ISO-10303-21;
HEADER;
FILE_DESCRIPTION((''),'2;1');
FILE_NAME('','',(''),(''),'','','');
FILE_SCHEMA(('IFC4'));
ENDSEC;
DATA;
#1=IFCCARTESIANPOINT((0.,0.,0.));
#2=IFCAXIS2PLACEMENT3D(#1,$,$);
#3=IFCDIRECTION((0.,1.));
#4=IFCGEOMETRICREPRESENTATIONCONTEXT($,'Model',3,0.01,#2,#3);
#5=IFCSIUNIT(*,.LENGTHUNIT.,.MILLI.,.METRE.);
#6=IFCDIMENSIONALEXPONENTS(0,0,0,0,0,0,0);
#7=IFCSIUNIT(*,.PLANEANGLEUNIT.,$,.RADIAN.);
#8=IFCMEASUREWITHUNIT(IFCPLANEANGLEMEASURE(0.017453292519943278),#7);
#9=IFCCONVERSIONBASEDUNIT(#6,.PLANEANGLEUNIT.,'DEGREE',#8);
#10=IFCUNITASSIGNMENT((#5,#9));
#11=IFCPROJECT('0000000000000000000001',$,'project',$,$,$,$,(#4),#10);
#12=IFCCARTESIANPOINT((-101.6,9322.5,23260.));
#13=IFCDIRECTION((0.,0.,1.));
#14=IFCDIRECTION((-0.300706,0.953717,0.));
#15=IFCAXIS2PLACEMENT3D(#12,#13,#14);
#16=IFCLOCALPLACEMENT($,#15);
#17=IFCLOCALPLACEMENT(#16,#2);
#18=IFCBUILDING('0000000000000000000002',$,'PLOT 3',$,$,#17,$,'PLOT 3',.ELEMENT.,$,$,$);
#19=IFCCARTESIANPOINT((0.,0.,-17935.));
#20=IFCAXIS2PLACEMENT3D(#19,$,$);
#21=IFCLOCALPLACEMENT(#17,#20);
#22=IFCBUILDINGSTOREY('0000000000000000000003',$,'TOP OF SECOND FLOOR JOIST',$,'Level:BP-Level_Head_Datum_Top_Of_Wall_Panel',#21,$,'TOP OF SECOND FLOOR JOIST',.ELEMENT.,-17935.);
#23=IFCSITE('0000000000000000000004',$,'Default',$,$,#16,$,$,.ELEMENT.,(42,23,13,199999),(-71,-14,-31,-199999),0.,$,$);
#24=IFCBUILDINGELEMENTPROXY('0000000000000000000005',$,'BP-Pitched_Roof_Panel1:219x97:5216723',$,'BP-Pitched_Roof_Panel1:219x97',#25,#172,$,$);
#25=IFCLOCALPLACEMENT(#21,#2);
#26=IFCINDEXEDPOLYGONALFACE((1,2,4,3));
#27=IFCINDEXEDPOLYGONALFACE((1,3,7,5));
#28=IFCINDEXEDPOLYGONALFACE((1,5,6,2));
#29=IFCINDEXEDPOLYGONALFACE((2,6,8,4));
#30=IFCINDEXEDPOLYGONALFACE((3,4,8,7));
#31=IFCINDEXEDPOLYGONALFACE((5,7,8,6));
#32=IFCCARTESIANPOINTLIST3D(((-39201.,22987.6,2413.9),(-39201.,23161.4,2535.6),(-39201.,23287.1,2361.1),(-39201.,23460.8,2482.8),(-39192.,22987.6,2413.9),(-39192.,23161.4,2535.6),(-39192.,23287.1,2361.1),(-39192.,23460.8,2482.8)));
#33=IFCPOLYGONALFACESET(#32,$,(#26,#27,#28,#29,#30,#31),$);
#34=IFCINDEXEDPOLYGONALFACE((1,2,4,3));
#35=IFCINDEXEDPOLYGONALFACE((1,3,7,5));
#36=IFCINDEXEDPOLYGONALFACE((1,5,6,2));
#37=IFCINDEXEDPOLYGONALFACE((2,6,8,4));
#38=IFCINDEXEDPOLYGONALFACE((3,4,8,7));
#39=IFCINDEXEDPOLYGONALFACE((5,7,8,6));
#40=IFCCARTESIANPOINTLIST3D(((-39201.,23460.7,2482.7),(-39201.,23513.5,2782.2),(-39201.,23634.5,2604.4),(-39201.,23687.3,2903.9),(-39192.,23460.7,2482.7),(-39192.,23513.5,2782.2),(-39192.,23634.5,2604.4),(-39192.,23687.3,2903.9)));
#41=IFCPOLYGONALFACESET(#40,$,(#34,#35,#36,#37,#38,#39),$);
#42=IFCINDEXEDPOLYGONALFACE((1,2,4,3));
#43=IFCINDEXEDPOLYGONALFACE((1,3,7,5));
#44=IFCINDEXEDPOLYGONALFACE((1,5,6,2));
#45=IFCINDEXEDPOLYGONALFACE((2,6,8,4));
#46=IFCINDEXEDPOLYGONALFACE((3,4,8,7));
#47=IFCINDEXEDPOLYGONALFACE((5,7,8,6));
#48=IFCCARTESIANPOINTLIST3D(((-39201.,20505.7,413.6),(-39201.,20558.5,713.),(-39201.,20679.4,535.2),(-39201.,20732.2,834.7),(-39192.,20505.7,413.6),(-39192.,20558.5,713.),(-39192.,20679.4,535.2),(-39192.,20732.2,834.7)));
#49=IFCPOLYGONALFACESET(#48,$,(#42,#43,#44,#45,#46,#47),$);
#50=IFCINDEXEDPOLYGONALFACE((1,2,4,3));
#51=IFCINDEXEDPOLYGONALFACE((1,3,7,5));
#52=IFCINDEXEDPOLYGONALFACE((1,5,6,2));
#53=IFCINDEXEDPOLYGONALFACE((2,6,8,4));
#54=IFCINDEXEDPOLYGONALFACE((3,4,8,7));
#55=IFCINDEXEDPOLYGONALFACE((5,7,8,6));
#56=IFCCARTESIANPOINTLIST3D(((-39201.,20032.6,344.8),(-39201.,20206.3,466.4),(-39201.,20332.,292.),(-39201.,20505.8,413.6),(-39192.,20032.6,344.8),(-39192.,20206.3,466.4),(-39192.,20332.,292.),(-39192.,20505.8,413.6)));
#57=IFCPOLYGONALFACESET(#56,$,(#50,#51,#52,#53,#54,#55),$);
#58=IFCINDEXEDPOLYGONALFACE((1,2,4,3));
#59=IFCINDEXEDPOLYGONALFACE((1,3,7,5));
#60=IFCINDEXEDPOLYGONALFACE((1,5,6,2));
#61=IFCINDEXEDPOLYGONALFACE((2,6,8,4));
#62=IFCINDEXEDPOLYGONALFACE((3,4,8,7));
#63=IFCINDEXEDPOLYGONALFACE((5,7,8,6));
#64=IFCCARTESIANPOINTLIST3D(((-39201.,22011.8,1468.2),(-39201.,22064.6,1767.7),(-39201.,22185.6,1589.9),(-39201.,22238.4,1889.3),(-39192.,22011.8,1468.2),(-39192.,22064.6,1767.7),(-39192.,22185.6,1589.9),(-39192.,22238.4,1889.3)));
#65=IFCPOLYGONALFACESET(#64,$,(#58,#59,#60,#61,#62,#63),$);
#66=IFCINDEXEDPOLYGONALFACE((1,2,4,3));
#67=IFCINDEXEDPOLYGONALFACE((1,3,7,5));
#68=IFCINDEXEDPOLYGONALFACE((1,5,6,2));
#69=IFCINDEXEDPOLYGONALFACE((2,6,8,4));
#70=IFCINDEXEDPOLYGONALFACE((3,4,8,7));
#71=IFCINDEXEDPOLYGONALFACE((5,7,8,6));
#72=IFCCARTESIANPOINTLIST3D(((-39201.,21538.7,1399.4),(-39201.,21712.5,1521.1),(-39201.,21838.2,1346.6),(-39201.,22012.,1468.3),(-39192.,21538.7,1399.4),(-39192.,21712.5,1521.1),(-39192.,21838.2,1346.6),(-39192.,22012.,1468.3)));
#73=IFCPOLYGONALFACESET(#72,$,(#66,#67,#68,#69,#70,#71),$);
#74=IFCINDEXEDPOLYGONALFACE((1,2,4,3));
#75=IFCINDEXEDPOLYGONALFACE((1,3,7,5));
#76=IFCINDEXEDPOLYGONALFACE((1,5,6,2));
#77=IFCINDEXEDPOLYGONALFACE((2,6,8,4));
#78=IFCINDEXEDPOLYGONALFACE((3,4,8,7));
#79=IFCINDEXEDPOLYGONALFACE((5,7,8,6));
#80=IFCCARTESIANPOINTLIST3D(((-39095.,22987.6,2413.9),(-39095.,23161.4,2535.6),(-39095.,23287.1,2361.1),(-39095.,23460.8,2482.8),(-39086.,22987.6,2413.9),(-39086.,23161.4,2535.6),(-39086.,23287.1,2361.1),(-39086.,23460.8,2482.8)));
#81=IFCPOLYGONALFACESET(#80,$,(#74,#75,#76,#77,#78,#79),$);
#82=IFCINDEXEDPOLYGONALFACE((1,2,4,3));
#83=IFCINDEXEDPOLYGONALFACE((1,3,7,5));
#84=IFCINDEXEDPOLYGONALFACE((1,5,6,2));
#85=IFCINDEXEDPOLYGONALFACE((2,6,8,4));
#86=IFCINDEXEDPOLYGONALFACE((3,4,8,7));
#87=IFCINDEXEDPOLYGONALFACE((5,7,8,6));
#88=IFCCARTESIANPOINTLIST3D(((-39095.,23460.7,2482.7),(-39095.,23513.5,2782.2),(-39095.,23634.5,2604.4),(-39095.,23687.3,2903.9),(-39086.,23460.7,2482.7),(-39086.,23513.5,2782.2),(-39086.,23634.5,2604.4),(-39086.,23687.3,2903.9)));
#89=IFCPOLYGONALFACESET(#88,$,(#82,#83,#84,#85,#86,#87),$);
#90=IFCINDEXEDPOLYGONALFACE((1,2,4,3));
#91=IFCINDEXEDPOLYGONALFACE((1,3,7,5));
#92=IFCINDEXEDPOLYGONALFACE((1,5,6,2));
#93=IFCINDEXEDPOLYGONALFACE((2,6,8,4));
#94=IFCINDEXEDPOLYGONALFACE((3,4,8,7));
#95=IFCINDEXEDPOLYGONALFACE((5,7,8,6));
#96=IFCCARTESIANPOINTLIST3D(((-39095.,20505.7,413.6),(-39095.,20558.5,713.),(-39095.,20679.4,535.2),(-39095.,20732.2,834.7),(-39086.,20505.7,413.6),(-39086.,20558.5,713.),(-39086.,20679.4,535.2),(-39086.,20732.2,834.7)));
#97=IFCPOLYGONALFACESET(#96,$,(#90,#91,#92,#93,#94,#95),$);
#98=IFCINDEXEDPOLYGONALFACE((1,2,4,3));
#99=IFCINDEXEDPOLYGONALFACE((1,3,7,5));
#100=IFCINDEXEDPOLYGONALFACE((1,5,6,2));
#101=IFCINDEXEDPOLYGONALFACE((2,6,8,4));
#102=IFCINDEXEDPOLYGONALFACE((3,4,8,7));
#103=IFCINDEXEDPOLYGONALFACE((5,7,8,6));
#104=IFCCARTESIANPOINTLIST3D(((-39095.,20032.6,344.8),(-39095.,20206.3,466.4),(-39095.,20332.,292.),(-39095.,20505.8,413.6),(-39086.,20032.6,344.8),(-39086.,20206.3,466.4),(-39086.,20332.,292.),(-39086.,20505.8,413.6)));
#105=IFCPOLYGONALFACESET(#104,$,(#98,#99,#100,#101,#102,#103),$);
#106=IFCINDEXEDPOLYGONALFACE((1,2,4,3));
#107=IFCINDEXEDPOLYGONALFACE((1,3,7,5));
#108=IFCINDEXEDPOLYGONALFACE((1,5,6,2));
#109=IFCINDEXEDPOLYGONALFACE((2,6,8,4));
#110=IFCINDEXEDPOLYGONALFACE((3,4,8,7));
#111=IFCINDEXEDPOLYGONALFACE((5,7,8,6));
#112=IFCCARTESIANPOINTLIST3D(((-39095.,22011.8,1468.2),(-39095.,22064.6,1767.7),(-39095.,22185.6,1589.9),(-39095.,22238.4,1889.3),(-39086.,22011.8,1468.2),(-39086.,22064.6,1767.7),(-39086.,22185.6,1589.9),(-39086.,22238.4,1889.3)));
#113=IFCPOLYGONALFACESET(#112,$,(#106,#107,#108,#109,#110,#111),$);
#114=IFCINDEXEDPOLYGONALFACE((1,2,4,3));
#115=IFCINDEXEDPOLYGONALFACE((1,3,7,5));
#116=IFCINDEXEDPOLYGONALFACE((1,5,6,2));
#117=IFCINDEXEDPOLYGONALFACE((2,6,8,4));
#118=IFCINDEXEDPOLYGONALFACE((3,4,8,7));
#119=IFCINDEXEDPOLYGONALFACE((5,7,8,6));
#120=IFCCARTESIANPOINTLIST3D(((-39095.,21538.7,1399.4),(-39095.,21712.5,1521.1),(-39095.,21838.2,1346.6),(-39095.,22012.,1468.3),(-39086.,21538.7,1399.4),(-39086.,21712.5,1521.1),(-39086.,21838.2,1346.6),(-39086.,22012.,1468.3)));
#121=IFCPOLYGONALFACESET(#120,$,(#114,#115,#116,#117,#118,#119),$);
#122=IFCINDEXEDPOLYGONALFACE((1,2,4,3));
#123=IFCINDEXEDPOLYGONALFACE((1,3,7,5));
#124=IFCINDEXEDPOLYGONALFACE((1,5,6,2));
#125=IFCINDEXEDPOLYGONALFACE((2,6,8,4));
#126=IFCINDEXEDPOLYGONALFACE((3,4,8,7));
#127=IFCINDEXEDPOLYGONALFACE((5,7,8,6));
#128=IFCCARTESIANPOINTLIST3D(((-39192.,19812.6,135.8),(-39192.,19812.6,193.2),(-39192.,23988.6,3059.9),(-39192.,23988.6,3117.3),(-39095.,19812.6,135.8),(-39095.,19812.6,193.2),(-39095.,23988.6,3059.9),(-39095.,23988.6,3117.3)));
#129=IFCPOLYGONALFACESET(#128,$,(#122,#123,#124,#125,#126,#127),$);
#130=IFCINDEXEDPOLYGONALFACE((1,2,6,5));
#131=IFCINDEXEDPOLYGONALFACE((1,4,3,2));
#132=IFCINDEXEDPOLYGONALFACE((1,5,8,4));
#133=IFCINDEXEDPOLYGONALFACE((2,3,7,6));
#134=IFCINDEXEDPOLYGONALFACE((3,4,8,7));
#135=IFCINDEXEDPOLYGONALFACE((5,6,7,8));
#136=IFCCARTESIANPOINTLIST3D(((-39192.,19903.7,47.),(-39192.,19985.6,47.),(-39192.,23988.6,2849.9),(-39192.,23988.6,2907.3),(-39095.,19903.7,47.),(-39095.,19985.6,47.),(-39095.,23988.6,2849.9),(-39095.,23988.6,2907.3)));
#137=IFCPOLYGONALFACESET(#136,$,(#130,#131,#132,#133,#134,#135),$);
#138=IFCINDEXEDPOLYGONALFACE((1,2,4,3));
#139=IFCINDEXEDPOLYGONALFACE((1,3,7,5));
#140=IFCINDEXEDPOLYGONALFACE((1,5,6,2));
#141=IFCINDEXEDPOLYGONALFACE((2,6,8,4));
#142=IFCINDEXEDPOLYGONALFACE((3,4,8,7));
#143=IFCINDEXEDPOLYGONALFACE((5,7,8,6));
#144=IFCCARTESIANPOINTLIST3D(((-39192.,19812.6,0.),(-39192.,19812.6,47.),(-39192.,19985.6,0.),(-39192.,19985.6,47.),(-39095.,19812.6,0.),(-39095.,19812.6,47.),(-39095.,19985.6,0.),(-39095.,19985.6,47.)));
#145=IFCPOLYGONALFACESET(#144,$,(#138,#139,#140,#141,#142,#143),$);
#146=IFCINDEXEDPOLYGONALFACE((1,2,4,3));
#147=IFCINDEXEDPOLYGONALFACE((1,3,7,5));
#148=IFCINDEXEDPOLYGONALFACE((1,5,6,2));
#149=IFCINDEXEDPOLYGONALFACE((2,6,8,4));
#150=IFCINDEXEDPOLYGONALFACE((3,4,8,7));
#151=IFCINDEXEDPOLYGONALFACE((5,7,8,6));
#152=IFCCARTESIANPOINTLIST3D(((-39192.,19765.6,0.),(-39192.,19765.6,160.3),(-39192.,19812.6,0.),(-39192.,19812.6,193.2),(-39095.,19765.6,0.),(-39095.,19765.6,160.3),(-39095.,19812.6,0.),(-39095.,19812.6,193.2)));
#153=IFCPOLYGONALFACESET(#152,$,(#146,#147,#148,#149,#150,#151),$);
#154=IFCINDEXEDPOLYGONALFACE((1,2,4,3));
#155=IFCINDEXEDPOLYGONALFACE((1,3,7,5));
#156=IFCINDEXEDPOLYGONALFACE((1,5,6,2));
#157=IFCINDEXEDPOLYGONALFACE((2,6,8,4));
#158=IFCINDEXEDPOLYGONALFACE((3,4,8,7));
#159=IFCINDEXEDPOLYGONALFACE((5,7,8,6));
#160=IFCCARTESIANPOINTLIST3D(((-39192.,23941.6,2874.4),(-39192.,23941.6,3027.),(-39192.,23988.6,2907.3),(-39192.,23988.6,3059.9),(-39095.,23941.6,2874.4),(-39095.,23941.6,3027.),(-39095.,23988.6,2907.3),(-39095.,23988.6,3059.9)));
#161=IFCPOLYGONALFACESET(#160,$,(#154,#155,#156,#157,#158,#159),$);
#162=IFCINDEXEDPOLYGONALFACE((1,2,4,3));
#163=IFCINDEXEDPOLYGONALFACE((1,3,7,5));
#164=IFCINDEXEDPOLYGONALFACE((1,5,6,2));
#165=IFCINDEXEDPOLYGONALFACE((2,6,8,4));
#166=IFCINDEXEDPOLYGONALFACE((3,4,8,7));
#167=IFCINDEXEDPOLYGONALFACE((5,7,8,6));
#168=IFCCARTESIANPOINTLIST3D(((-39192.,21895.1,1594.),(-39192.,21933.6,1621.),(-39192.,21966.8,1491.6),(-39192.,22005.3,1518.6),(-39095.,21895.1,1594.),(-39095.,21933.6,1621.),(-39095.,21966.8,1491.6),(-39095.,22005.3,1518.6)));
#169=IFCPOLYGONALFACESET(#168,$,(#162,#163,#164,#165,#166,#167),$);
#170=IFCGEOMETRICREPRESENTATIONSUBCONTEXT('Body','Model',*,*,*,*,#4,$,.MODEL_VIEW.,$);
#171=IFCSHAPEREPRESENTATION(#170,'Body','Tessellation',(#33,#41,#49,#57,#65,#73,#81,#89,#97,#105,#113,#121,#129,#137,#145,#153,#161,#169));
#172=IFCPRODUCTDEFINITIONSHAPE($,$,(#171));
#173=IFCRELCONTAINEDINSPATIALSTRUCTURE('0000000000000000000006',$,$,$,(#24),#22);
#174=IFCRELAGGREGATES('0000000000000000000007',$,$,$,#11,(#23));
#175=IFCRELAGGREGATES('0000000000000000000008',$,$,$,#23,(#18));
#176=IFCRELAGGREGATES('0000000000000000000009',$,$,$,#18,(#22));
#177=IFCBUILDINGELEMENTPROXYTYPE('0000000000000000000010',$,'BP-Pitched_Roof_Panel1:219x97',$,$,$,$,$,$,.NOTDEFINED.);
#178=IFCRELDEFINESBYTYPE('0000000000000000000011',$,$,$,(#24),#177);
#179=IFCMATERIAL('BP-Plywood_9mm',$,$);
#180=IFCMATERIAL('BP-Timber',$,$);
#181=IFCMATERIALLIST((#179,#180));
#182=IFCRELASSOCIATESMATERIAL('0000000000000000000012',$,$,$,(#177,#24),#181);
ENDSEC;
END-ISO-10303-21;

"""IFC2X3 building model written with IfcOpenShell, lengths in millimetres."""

from ifc_helpers import new_model, entity, si_unit, converted_unit, direction, frame, frame_2d, origin, origin_2d_with_axis, place, context, subcontext, project, spatial, polyline, rectangle, outline, extrude, source, transform, mapped, material, material_list, type_object, type_shapes, element, save


model = new_model("IFC2X3")

# Units and contexts
model_context = context("Model", 3, precision=0.01, world=origin(), true_north=direction((0.0, 1.0)))
body_context = subcontext(model_context, "Body", "Model", "MODEL_VIEW")
ifc_project = project(units=[si_unit("LENGTHUNIT", "METRE", prefix="MILLI"), converted_unit("PLANEANGLEUNIT", "DEGREE", entity("IfcPlaneAngleMeasure", 0.017453292519943278), si_unit("PLANEANGLEUNIT", "RADIAN"), dimensions=[0, 0, 0, 0, 0, 0, 0])], contexts=[model_context])

# Site, building, storey
site_placement = place(None, frame((-101.6, 9322.5, 23260.0), z_axis=(0.0, 0.0, 1.0), x_axis=(-0.300706, 0.953717, 0.0)))
site = spatial("IfcSite", under=ifc_project, at=site_placement, Name="Default", CompositionType="ELEMENT", RefLatitude=(42, 23, 13, 199999), RefLongitude=(-71, -14, -31, -199999), RefElevation=0.0)
building_placement = place(site_placement, origin())
building = spatial("IfcBuilding", under=site, at=building_placement, Name="PLOT 3", LongName="PLOT 3", CompositionType="ELEMENT")
storey_placement = place(building_placement, frame((0.0, 0.0, -17935.0)))
storey = spatial("IfcBuildingStorey", under=building, at=storey_placement, Name="TOP OF SECOND FLOOR JOIST", ObjectType="Level:BP-Level_Head_Datum_Top_Of_Wall_Panel", LongName="TOP OF SECOND FLOOR JOIST", CompositionType="ELEMENT", Elevation=-17935.0)

# Building element proxy
ifc_material_1 = material(Name="BP-Timber")
ifc_material_2 = material(Name="BP-Plywood_9mm")
ifc_material_list = material_list([ifc_material_2, ifc_material_1])
building_element_proxy_type_1 = type_object("IfcBuildingElementProxyType", Name="BP-Pitched_Roof_Panel1:219x97", PredefinedType="NOTDEFINED", material=ifc_material_list)
shared_shape_1 = source(origin(), body_context, "Body", "SweptSolid", [
    extrude(outline(polyline([(-77.0, -75.0), (227.0, -75.0), (77.0, 75.0), (-227.0, 75.0), (-77.0, -75.0)])), frame((36.3, 3947.0, 2448.4), z_axis=(0.0, 1.0, 0.0), x_axis=(-0.984808, 0.0, 0.173648)), (0.0, 0.0, 1.0), 9.0),
    extrude(outline(polyline([(1.4, -107.5), (213.6, -107.5), (-1.4, 107.5), (-213.6, 107.5), (1.4, -107.5)])), frame((386.1, 3947.0, 2693.3), z_axis=(0.0, 1.0, 0.0), x_axis=(-0.819152, 0.0, -0.573576)), (0.0, 0.0, 1.0), 9.0),
    extrude(outline(polyline([(1.4, -107.5), (213.6, -107.5), (-1.4, 107.5), (-213.6, 107.5), (1.4, -107.5)])), frame((-2569.0, 3947.0, 624.1), z_axis=(0.0, 1.0, 0.0), x_axis=(-0.819152, 0.0, -0.573576)), (0.0, 0.0, 1.0), 9.0),
    extrude(outline(polyline([(-77.0, -75.0), (227.0, -75.0), (77.0, 75.0), (-227.0, 75.0), (-77.0, -75.0)])), frame((-2918.8, 3947.0, 379.2), z_axis=(0.0, 1.0, 0.0), x_axis=(-0.984808, 0.0, 0.173648)), (0.0, 0.0, 1.0), 9.0),
    extrude(outline(polyline([(1.4, -107.5), (213.6, -107.5), (-1.4, 107.5), (-213.6, 107.5), (1.4, -107.5)])), frame((-1062.8, 3947.0, 1678.8), z_axis=(0.0, 1.0, 0.0), x_axis=(-0.819152, 0.0, -0.573576)), (0.0, 0.0, 1.0), 9.0),
    extrude(outline(polyline([(-77.0, -75.0), (227.0, -75.0), (77.0, 75.0), (-227.0, 75.0), (-77.0, -75.0)])), frame((-1412.6, 3947.0, 1433.9), z_axis=(0.0, 1.0, 0.0), x_axis=(-0.984808, 0.0, 0.173648)), (0.0, 0.0, 1.0), 9.0),
    extrude(outline(polyline([(-77.0, -75.0), (227.0, -75.0), (77.0, 75.0), (-227.0, 75.0), (-77.0, -75.0)])), frame((36.3, 3841.0, 2448.4), z_axis=(0.0, 1.0, 0.0), x_axis=(-0.984808, 0.0, 0.173648)), (0.0, 0.0, 1.0), 9.0),
    extrude(outline(polyline([(1.4, -107.5), (213.6, -107.5), (-1.4, 107.5), (-213.6, 107.5), (1.4, -107.5)])), frame((386.1, 3841.0, 2693.3), z_axis=(0.0, 1.0, 0.0), x_axis=(-0.819152, 0.0, -0.573576)), (0.0, 0.0, 1.0), 9.0),
    extrude(outline(polyline([(1.4, -107.5), (213.6, -107.5), (-1.4, 107.5), (-213.6, 107.5), (1.4, -107.5)])), frame((-2569.0, 3841.0, 624.1), z_axis=(0.0, 1.0, 0.0), x_axis=(-0.819152, 0.0, -0.573576)), (0.0, 0.0, 1.0), 9.0),
    extrude(outline(polyline([(-77.0, -75.0), (227.0, -75.0), (77.0, 75.0), (-227.0, 75.0), (-77.0, -75.0)])), frame((-2918.8, 3841.0, 379.2), z_axis=(0.0, 1.0, 0.0), x_axis=(-0.984808, 0.0, 0.173648)), (0.0, 0.0, 1.0), 9.0),
    extrude(outline(polyline([(1.4, -107.5), (213.6, -107.5), (-1.4, 107.5), (-213.6, 107.5), (1.4, -107.5)])), frame((-1062.8, 3841.0, 1678.8), z_axis=(0.0, 1.0, 0.0), x_axis=(-0.819152, 0.0, -0.573576)), (0.0, 0.0, 1.0), 9.0),
    extrude(outline(polyline([(-77.0, -75.0), (227.0, -75.0), (77.0, 75.0), (-227.0, 75.0), (-77.0, -75.0)])), frame((-1412.6, 3841.0, 1433.9), z_axis=(0.0, 1.0, 0.0), x_axis=(-0.984808, 0.0, 0.173648)), (0.0, 0.0, 1.0), 9.0),
    extrude(outline(polyline([(-1490.7, -2088.0), (-1433.3, -2088.0), (1490.7, 2088.0), (1433.3, 2088.0), (-1490.7, -2088.0)])), frame((-1287.3, 3850.0, 1626.6), z_axis=(0.0, 1.0, 0.0), x_axis=(0.0, 0.0, -1.0)), (0.0, 0.0, 1.0), 97.0),
    extrude(outline(polyline([(-1444.5, -2022.0), (-1387.1, -2022.0), (1415.8, 1981.0), (1415.8, 2063.0), (-1444.5, -2022.0)])), frame((-1221.3, 3850.0, 1462.8), z_axis=(0.0, 1.0, 0.0), x_axis=(0.0, 0.0, -1.0)), (0.0, 0.0, 1.0), 97.0),
    extrude(rectangle(XDim=97.0, YDim=173.0, at=origin_2d_with_axis()), frame((-3288.8, 3898.5, 0.0), z_axis=(0.0, 0.0, 1.0), x_axis=(0.0, 1.0, 0.0)), (0.0, 0.0, 1.0), 47.0),
    extrude(outline(polyline([(22.0, -72.4), (79.4, -72.4), (-31.4, 85.9), (-69.9, 58.9), (22.0, -72.4)])), frame((-3398.8, 3850.0, 88.4), z_axis=(0.0, 1.0, 0.0), x_axis=(0.819152, 0.0, 0.573576)), (0.0, 0.0, 1.0), 97.0),
    extrude(outline(polyline([(15.1, -62.5), (72.5, -62.5), (-15.1, 62.5), (-72.5, 62.5), (15.1, -62.5)])), frame((777.2, 3850.0, 2967.2), z_axis=(0.0, 1.0, 0.0), x_axis=(0.819152, 0.0, 0.573576)), (0.0, 0.0, 1.0), 97.0),
    extrude(rectangle(XDim=47.0, YDim=97.0, at=frame_2d((0.0, 0.0), x_axis=(0.0, 1.0))), frame((-1201.9, 3898.5, 1505.1), z_axis=(-0.573576, 0.0, 0.819152), x_axis=(0.0, 1.0, 0.0)), (0.0, 0.0, 1.0), 125.0),
])
type_shapes(building_element_proxy_type_1, [shared_shape_1])
for number, where, z_axis, x_axis, name in (
    (1, (-35245.0, 23187.9, 0.0), (0.0, 0.0, 1.0), (0.0, 1.0, 0.0), "BP-Pitched_Roof_Panel1:219x97:5216723"),
):
    element("IfcBuildingElementProxy", number, at=place(storey_placement, frame(where, z_axis=z_axis, x_axis=x_axis)), inside=storey, type_object=building_element_proxy_type_1, material=ifc_material_list, Name=name, ObjectType="BP-Pitched_Roof_Panel1:219x97", context=body_context, shape_type="MappedRepresentation", body=[
        mapped(shared_shape_1, transform((0.0, 0.0, 0.0), scale=1.0)),
    ])

save(model, "model.ifc")
